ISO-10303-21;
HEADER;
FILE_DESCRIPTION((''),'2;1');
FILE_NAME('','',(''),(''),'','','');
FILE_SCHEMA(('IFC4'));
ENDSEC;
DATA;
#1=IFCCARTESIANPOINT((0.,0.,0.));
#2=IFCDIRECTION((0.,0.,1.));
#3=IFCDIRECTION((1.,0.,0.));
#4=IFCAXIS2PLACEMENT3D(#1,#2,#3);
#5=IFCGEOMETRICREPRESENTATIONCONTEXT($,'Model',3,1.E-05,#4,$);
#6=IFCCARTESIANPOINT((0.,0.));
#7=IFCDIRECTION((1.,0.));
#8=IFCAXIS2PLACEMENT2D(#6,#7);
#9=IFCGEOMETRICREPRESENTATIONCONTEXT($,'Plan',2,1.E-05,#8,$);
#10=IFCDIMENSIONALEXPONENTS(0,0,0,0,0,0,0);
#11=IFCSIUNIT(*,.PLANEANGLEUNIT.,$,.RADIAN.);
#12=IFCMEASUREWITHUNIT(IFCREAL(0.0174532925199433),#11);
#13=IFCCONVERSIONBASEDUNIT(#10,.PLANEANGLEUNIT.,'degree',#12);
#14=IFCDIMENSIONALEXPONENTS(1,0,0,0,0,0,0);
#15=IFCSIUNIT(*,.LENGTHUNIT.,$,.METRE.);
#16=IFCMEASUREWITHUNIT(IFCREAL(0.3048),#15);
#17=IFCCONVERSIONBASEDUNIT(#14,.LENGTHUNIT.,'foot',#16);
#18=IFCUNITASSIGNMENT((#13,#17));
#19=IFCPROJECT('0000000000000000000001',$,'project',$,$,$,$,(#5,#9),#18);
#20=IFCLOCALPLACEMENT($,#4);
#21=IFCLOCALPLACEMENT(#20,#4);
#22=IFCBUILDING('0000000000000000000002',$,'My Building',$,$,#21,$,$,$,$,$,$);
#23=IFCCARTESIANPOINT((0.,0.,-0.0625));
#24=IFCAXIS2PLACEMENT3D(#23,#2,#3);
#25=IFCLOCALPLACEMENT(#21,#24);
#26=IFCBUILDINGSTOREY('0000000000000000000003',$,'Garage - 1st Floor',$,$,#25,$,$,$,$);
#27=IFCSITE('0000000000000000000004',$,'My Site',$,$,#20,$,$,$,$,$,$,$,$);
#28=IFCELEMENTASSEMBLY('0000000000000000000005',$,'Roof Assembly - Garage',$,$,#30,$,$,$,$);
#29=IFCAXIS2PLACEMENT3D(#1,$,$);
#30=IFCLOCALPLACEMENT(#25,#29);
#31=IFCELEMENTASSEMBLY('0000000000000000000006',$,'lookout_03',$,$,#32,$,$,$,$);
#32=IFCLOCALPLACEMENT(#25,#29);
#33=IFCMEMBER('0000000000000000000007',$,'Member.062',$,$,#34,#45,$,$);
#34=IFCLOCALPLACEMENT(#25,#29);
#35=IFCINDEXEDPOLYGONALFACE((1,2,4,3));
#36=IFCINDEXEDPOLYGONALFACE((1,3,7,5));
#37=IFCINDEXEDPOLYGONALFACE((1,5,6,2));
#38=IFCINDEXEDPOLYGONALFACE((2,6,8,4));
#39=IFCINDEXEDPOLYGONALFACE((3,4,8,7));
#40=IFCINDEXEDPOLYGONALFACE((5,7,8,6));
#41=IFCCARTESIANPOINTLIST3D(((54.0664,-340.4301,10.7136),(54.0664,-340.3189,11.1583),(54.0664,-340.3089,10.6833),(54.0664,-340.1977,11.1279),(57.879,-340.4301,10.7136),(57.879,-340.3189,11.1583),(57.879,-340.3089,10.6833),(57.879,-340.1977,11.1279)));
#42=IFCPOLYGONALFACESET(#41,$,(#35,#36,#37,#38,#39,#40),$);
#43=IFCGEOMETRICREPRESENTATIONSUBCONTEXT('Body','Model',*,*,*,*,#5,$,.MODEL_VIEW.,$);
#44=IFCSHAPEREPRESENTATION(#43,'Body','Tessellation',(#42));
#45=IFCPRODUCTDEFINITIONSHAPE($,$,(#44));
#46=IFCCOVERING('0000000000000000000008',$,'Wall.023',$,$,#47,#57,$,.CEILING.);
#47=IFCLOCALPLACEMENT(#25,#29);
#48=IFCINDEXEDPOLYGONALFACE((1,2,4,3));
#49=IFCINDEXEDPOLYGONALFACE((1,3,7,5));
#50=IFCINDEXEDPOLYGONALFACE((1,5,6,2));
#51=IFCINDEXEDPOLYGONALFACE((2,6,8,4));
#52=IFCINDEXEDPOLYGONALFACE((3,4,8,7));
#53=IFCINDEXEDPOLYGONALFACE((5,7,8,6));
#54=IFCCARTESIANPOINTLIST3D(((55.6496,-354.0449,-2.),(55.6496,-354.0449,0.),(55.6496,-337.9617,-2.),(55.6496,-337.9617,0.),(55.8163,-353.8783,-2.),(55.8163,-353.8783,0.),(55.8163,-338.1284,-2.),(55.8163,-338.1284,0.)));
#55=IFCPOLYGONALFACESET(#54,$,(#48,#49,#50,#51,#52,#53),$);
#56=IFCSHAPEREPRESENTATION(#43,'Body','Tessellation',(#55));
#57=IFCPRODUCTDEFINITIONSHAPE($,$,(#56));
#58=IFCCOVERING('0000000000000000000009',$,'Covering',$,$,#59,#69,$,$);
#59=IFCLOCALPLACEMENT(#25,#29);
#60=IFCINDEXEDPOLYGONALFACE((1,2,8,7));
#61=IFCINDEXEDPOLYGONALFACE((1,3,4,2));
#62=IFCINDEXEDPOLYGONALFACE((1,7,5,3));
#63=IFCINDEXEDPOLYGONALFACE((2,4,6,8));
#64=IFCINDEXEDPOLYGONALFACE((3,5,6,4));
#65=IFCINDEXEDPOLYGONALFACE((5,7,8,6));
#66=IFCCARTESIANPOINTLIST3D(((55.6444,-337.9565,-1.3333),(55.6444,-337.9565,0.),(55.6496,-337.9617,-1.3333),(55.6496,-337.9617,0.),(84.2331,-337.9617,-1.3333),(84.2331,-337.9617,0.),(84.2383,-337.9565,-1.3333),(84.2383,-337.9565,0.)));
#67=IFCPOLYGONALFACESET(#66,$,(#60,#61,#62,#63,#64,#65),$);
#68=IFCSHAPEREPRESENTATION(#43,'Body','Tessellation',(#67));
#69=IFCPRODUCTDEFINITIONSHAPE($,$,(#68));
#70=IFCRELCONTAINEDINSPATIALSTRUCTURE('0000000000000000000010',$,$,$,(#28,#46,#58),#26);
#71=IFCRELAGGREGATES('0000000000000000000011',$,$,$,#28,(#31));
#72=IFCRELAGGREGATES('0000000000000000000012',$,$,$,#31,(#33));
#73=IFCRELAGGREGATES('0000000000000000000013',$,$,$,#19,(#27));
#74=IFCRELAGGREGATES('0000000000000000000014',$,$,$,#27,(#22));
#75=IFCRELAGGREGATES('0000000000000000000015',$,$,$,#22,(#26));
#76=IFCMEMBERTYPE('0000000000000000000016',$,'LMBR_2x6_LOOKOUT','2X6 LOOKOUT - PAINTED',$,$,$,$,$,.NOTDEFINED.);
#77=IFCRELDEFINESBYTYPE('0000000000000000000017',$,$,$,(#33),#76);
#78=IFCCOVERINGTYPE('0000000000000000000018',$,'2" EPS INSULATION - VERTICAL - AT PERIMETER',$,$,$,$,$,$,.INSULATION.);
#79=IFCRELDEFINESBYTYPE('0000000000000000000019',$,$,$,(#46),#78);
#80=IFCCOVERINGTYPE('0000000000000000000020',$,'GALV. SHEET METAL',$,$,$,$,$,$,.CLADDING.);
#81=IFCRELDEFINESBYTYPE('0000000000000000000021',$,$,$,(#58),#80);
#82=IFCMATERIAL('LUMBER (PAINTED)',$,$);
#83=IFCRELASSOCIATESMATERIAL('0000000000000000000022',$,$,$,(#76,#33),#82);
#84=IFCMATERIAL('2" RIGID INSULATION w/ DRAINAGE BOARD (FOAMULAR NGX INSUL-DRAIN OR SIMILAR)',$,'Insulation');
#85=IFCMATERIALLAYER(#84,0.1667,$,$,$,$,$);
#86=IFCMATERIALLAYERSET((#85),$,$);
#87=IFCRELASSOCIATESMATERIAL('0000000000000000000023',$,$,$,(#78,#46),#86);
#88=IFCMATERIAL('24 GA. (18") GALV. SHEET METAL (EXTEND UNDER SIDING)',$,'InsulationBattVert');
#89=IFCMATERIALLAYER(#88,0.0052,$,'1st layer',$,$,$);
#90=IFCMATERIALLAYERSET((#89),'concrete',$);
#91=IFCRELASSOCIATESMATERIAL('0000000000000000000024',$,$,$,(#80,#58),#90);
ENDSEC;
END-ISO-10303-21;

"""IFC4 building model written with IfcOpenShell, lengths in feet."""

from ifc_helpers import new_model, entity, si_unit, converted_unit, frame, origin_with_axes, origin_2d_with_axis, place, context, subcontext, project, spatial, line, indexed_curve, outline, extrude, material, layer, layer_set, layer_usage, material_profile, profile_set, profile_usage, type_object, element, aggregate, save


model = new_model("IFC4")

# Units and contexts
model_context = context("Model", 3, precision=1e-05, world=origin_with_axes())
plan_context = context("Plan", 2, precision=1e-05, world=origin_2d_with_axis())
body_context = subcontext(model_context, "Body", "Model", "MODEL_VIEW")
ifc_project = project(units=[converted_unit("PLANEANGLEUNIT", "degree", entity("IfcReal", 0.0174532925199433), si_unit("PLANEANGLEUNIT", "RADIAN"), dimensions=[0, 0, 0, 0, 0, 0, 0]), converted_unit("LENGTHUNIT", "foot", entity("IfcReal", 0.3048), si_unit("LENGTHUNIT", "METRE"), dimensions=[1, 0, 0, 0, 0, 0, 0])], contexts=[model_context, plan_context])

# Site, building, storey
site_placement = place(None, origin_with_axes())
site = spatial("IfcSite", under=ifc_project, at=site_placement, Name="My Site")
building_placement = place(site_placement, origin_with_axes())
building = spatial("IfcBuilding", under=site, at=building_placement, Name="My Building")
storey_placement = place(building_placement, frame((0.0, 0.0, -0.0625), z_axis=(0.0, 0.0, 1.0), x_axis=(1.0, 0.0, 0.0)))
storey = spatial("IfcBuildingStorey", under=building, at=storey_placement, Name="Garage - 1st Floor")

# Element assemblies, member
assembly_1_placement = place(storey_placement, frame((0.0, 0.0, 0.125), z_axis=(0.0, 0.0, 1.0), x_axis=(1.0, 0.0, 0.0)))
assembly_1 = element("IfcElementAssembly", 1, at=assembly_1_placement, inside=storey, Name="Roof Assembly - Garage")
ifc_material_1 = material(Name="LUMBER (PAINTED)")
assembly_2_placement = place(assembly_1_placement, frame((57.9415, -346.0033, 12.5192), z_axis=(0.0, 0.0, 1.0), x_axis=(-0.000001, 1.0, 0.0)))
assembly_2 = element("IfcElementAssembly", 2, at=assembly_2_placement, Name="lookout_03")
aggregate(assembly_1, [assembly_2])
ifc_material_profile_1 = material_profile(ifc_material_1, outline(indexed_curve([(-0.0625, 0.2292), (0.0625, 0.2292), (0.0625, -0.2292), (-0.0625, -0.2292), (-0.0625, 0.2292)])))
ifc_profile_set_1 = profile_set([ifc_material_profile_1])
member_type_1 = type_object("IfcMemberType", Name="LMBR_2x6_LOOKOUT", Description="2X6 LOOKOUT - PAINTED", PredefinedType="NOTDEFINED", material=ifc_profile_set_1)
ifc_profile_usage_1 = profile_usage(ifc_profile_set_1)
member_1_placement = place(assembly_2_placement, frame((5.6894, 0.0625, -1.7234), z_axis=(0.0, 1.0, 0.0), x_axis=(-0.970127, 0.0, 0.242599)))
member_1 = element("IfcMember", 3, at=member_1_placement, type_object=member_type_1, material=ifc_profile_usage_1, Name="Member.062", context=body_context, shape_type="SweptSolid", body=[
    extrude(outline(indexed_curve([(-0.0625, 0.2292), (0.0625, 0.2292), (0.0625, -0.2292), (-0.0625, -0.2292), (-0.0625, 0.2292)])), origin_with_axes(), (0.0, 0.0, 1.0), 3.8125),
])
aggregate(assembly_2, [member_1])

# Coverings
ifc_material_2 = material(Name="2\" RIGID INSULATION w/ DRAINAGE BOARD (FOAMULAR NGX INSUL-DRAIN OR SIMILAR)", Category="Insulation")
ifc_layer_1 = layer(ifc_material_2, 0.1667)
ifc_layer_set_1 = layer_set([ifc_layer_1])
ifc_layer_usage_1 = layer_usage(ifc_layer_set_1, "AXIS2", "POSITIVE", 0.0)
covering_type_1 = type_object("IfcCoveringType", Name="2\" EPS INSULATION - VERTICAL - AT PERIMETER", PredefinedType="INSULATION", material=ifc_layer_set_1)
covering_1_placement = place(storey_placement, frame((55.6496, -337.9617, -2.0), z_axis=(0.0, 0.0, 1.0), x_axis=(0.0, -1.0, 0.0)))
element("IfcCovering", 4, at=covering_1_placement, inside=storey, type_object=covering_type_1, material=ifc_layer_usage_1, Name="Wall.023", PredefinedType="CEILING", context=body_context, shape_type="SweptSolid", body=[
    extrude(outline(indexed_curve([(0.0, 0.0), (0.1667, 0.1667), (15.9166, 0.1667), (16.0832, 0.0)], segments=[line(1, 2, 3, 4, 1)])), origin_with_axes(), (0.0, 0.0, 1.0), 2.0),
])
ifc_material_3 = material(Name="24 GA. (18\") GALV. SHEET METAL (EXTEND UNDER SIDING)", Category="InsulationBattVert")
ifc_layer_2 = layer(ifc_material_3, 0.0052, Name="1st layer")
ifc_layer_set_2 = layer_set([ifc_layer_2], Name="concrete")
ifc_layer_usage_2 = layer_usage(ifc_layer_set_2, "AXIS2", "POSITIVE", 0.0)
covering_type_2 = type_object("IfcCoveringType", Name="GALV. SHEET METAL", PredefinedType="CLADDING", material=ifc_layer_set_2)
covering_2_placement = place(storey_placement, frame((55.6496, -337.9617, -1.3333), z_axis=(0.0, 0.0, 1.0), x_axis=(1.0, 0.0, 0.0)))
element("IfcCovering", 5, at=covering_2_placement, inside=storey, type_object=covering_type_2, material=ifc_layer_usage_2, Name="Covering", context=body_context, shape_type="SweptSolid", body=[
    extrude(outline(indexed_curve([(0.0, 0.0), (-0.0052, 0.0052), (28.5887, 0.0052), (28.5835, 0.0)], segments=[line(1, 2, 3, 4, 1)])), origin_with_axes(), (0.0, 0.0, 1.0), 1.3333),
])

save(model, "model.ifc")
